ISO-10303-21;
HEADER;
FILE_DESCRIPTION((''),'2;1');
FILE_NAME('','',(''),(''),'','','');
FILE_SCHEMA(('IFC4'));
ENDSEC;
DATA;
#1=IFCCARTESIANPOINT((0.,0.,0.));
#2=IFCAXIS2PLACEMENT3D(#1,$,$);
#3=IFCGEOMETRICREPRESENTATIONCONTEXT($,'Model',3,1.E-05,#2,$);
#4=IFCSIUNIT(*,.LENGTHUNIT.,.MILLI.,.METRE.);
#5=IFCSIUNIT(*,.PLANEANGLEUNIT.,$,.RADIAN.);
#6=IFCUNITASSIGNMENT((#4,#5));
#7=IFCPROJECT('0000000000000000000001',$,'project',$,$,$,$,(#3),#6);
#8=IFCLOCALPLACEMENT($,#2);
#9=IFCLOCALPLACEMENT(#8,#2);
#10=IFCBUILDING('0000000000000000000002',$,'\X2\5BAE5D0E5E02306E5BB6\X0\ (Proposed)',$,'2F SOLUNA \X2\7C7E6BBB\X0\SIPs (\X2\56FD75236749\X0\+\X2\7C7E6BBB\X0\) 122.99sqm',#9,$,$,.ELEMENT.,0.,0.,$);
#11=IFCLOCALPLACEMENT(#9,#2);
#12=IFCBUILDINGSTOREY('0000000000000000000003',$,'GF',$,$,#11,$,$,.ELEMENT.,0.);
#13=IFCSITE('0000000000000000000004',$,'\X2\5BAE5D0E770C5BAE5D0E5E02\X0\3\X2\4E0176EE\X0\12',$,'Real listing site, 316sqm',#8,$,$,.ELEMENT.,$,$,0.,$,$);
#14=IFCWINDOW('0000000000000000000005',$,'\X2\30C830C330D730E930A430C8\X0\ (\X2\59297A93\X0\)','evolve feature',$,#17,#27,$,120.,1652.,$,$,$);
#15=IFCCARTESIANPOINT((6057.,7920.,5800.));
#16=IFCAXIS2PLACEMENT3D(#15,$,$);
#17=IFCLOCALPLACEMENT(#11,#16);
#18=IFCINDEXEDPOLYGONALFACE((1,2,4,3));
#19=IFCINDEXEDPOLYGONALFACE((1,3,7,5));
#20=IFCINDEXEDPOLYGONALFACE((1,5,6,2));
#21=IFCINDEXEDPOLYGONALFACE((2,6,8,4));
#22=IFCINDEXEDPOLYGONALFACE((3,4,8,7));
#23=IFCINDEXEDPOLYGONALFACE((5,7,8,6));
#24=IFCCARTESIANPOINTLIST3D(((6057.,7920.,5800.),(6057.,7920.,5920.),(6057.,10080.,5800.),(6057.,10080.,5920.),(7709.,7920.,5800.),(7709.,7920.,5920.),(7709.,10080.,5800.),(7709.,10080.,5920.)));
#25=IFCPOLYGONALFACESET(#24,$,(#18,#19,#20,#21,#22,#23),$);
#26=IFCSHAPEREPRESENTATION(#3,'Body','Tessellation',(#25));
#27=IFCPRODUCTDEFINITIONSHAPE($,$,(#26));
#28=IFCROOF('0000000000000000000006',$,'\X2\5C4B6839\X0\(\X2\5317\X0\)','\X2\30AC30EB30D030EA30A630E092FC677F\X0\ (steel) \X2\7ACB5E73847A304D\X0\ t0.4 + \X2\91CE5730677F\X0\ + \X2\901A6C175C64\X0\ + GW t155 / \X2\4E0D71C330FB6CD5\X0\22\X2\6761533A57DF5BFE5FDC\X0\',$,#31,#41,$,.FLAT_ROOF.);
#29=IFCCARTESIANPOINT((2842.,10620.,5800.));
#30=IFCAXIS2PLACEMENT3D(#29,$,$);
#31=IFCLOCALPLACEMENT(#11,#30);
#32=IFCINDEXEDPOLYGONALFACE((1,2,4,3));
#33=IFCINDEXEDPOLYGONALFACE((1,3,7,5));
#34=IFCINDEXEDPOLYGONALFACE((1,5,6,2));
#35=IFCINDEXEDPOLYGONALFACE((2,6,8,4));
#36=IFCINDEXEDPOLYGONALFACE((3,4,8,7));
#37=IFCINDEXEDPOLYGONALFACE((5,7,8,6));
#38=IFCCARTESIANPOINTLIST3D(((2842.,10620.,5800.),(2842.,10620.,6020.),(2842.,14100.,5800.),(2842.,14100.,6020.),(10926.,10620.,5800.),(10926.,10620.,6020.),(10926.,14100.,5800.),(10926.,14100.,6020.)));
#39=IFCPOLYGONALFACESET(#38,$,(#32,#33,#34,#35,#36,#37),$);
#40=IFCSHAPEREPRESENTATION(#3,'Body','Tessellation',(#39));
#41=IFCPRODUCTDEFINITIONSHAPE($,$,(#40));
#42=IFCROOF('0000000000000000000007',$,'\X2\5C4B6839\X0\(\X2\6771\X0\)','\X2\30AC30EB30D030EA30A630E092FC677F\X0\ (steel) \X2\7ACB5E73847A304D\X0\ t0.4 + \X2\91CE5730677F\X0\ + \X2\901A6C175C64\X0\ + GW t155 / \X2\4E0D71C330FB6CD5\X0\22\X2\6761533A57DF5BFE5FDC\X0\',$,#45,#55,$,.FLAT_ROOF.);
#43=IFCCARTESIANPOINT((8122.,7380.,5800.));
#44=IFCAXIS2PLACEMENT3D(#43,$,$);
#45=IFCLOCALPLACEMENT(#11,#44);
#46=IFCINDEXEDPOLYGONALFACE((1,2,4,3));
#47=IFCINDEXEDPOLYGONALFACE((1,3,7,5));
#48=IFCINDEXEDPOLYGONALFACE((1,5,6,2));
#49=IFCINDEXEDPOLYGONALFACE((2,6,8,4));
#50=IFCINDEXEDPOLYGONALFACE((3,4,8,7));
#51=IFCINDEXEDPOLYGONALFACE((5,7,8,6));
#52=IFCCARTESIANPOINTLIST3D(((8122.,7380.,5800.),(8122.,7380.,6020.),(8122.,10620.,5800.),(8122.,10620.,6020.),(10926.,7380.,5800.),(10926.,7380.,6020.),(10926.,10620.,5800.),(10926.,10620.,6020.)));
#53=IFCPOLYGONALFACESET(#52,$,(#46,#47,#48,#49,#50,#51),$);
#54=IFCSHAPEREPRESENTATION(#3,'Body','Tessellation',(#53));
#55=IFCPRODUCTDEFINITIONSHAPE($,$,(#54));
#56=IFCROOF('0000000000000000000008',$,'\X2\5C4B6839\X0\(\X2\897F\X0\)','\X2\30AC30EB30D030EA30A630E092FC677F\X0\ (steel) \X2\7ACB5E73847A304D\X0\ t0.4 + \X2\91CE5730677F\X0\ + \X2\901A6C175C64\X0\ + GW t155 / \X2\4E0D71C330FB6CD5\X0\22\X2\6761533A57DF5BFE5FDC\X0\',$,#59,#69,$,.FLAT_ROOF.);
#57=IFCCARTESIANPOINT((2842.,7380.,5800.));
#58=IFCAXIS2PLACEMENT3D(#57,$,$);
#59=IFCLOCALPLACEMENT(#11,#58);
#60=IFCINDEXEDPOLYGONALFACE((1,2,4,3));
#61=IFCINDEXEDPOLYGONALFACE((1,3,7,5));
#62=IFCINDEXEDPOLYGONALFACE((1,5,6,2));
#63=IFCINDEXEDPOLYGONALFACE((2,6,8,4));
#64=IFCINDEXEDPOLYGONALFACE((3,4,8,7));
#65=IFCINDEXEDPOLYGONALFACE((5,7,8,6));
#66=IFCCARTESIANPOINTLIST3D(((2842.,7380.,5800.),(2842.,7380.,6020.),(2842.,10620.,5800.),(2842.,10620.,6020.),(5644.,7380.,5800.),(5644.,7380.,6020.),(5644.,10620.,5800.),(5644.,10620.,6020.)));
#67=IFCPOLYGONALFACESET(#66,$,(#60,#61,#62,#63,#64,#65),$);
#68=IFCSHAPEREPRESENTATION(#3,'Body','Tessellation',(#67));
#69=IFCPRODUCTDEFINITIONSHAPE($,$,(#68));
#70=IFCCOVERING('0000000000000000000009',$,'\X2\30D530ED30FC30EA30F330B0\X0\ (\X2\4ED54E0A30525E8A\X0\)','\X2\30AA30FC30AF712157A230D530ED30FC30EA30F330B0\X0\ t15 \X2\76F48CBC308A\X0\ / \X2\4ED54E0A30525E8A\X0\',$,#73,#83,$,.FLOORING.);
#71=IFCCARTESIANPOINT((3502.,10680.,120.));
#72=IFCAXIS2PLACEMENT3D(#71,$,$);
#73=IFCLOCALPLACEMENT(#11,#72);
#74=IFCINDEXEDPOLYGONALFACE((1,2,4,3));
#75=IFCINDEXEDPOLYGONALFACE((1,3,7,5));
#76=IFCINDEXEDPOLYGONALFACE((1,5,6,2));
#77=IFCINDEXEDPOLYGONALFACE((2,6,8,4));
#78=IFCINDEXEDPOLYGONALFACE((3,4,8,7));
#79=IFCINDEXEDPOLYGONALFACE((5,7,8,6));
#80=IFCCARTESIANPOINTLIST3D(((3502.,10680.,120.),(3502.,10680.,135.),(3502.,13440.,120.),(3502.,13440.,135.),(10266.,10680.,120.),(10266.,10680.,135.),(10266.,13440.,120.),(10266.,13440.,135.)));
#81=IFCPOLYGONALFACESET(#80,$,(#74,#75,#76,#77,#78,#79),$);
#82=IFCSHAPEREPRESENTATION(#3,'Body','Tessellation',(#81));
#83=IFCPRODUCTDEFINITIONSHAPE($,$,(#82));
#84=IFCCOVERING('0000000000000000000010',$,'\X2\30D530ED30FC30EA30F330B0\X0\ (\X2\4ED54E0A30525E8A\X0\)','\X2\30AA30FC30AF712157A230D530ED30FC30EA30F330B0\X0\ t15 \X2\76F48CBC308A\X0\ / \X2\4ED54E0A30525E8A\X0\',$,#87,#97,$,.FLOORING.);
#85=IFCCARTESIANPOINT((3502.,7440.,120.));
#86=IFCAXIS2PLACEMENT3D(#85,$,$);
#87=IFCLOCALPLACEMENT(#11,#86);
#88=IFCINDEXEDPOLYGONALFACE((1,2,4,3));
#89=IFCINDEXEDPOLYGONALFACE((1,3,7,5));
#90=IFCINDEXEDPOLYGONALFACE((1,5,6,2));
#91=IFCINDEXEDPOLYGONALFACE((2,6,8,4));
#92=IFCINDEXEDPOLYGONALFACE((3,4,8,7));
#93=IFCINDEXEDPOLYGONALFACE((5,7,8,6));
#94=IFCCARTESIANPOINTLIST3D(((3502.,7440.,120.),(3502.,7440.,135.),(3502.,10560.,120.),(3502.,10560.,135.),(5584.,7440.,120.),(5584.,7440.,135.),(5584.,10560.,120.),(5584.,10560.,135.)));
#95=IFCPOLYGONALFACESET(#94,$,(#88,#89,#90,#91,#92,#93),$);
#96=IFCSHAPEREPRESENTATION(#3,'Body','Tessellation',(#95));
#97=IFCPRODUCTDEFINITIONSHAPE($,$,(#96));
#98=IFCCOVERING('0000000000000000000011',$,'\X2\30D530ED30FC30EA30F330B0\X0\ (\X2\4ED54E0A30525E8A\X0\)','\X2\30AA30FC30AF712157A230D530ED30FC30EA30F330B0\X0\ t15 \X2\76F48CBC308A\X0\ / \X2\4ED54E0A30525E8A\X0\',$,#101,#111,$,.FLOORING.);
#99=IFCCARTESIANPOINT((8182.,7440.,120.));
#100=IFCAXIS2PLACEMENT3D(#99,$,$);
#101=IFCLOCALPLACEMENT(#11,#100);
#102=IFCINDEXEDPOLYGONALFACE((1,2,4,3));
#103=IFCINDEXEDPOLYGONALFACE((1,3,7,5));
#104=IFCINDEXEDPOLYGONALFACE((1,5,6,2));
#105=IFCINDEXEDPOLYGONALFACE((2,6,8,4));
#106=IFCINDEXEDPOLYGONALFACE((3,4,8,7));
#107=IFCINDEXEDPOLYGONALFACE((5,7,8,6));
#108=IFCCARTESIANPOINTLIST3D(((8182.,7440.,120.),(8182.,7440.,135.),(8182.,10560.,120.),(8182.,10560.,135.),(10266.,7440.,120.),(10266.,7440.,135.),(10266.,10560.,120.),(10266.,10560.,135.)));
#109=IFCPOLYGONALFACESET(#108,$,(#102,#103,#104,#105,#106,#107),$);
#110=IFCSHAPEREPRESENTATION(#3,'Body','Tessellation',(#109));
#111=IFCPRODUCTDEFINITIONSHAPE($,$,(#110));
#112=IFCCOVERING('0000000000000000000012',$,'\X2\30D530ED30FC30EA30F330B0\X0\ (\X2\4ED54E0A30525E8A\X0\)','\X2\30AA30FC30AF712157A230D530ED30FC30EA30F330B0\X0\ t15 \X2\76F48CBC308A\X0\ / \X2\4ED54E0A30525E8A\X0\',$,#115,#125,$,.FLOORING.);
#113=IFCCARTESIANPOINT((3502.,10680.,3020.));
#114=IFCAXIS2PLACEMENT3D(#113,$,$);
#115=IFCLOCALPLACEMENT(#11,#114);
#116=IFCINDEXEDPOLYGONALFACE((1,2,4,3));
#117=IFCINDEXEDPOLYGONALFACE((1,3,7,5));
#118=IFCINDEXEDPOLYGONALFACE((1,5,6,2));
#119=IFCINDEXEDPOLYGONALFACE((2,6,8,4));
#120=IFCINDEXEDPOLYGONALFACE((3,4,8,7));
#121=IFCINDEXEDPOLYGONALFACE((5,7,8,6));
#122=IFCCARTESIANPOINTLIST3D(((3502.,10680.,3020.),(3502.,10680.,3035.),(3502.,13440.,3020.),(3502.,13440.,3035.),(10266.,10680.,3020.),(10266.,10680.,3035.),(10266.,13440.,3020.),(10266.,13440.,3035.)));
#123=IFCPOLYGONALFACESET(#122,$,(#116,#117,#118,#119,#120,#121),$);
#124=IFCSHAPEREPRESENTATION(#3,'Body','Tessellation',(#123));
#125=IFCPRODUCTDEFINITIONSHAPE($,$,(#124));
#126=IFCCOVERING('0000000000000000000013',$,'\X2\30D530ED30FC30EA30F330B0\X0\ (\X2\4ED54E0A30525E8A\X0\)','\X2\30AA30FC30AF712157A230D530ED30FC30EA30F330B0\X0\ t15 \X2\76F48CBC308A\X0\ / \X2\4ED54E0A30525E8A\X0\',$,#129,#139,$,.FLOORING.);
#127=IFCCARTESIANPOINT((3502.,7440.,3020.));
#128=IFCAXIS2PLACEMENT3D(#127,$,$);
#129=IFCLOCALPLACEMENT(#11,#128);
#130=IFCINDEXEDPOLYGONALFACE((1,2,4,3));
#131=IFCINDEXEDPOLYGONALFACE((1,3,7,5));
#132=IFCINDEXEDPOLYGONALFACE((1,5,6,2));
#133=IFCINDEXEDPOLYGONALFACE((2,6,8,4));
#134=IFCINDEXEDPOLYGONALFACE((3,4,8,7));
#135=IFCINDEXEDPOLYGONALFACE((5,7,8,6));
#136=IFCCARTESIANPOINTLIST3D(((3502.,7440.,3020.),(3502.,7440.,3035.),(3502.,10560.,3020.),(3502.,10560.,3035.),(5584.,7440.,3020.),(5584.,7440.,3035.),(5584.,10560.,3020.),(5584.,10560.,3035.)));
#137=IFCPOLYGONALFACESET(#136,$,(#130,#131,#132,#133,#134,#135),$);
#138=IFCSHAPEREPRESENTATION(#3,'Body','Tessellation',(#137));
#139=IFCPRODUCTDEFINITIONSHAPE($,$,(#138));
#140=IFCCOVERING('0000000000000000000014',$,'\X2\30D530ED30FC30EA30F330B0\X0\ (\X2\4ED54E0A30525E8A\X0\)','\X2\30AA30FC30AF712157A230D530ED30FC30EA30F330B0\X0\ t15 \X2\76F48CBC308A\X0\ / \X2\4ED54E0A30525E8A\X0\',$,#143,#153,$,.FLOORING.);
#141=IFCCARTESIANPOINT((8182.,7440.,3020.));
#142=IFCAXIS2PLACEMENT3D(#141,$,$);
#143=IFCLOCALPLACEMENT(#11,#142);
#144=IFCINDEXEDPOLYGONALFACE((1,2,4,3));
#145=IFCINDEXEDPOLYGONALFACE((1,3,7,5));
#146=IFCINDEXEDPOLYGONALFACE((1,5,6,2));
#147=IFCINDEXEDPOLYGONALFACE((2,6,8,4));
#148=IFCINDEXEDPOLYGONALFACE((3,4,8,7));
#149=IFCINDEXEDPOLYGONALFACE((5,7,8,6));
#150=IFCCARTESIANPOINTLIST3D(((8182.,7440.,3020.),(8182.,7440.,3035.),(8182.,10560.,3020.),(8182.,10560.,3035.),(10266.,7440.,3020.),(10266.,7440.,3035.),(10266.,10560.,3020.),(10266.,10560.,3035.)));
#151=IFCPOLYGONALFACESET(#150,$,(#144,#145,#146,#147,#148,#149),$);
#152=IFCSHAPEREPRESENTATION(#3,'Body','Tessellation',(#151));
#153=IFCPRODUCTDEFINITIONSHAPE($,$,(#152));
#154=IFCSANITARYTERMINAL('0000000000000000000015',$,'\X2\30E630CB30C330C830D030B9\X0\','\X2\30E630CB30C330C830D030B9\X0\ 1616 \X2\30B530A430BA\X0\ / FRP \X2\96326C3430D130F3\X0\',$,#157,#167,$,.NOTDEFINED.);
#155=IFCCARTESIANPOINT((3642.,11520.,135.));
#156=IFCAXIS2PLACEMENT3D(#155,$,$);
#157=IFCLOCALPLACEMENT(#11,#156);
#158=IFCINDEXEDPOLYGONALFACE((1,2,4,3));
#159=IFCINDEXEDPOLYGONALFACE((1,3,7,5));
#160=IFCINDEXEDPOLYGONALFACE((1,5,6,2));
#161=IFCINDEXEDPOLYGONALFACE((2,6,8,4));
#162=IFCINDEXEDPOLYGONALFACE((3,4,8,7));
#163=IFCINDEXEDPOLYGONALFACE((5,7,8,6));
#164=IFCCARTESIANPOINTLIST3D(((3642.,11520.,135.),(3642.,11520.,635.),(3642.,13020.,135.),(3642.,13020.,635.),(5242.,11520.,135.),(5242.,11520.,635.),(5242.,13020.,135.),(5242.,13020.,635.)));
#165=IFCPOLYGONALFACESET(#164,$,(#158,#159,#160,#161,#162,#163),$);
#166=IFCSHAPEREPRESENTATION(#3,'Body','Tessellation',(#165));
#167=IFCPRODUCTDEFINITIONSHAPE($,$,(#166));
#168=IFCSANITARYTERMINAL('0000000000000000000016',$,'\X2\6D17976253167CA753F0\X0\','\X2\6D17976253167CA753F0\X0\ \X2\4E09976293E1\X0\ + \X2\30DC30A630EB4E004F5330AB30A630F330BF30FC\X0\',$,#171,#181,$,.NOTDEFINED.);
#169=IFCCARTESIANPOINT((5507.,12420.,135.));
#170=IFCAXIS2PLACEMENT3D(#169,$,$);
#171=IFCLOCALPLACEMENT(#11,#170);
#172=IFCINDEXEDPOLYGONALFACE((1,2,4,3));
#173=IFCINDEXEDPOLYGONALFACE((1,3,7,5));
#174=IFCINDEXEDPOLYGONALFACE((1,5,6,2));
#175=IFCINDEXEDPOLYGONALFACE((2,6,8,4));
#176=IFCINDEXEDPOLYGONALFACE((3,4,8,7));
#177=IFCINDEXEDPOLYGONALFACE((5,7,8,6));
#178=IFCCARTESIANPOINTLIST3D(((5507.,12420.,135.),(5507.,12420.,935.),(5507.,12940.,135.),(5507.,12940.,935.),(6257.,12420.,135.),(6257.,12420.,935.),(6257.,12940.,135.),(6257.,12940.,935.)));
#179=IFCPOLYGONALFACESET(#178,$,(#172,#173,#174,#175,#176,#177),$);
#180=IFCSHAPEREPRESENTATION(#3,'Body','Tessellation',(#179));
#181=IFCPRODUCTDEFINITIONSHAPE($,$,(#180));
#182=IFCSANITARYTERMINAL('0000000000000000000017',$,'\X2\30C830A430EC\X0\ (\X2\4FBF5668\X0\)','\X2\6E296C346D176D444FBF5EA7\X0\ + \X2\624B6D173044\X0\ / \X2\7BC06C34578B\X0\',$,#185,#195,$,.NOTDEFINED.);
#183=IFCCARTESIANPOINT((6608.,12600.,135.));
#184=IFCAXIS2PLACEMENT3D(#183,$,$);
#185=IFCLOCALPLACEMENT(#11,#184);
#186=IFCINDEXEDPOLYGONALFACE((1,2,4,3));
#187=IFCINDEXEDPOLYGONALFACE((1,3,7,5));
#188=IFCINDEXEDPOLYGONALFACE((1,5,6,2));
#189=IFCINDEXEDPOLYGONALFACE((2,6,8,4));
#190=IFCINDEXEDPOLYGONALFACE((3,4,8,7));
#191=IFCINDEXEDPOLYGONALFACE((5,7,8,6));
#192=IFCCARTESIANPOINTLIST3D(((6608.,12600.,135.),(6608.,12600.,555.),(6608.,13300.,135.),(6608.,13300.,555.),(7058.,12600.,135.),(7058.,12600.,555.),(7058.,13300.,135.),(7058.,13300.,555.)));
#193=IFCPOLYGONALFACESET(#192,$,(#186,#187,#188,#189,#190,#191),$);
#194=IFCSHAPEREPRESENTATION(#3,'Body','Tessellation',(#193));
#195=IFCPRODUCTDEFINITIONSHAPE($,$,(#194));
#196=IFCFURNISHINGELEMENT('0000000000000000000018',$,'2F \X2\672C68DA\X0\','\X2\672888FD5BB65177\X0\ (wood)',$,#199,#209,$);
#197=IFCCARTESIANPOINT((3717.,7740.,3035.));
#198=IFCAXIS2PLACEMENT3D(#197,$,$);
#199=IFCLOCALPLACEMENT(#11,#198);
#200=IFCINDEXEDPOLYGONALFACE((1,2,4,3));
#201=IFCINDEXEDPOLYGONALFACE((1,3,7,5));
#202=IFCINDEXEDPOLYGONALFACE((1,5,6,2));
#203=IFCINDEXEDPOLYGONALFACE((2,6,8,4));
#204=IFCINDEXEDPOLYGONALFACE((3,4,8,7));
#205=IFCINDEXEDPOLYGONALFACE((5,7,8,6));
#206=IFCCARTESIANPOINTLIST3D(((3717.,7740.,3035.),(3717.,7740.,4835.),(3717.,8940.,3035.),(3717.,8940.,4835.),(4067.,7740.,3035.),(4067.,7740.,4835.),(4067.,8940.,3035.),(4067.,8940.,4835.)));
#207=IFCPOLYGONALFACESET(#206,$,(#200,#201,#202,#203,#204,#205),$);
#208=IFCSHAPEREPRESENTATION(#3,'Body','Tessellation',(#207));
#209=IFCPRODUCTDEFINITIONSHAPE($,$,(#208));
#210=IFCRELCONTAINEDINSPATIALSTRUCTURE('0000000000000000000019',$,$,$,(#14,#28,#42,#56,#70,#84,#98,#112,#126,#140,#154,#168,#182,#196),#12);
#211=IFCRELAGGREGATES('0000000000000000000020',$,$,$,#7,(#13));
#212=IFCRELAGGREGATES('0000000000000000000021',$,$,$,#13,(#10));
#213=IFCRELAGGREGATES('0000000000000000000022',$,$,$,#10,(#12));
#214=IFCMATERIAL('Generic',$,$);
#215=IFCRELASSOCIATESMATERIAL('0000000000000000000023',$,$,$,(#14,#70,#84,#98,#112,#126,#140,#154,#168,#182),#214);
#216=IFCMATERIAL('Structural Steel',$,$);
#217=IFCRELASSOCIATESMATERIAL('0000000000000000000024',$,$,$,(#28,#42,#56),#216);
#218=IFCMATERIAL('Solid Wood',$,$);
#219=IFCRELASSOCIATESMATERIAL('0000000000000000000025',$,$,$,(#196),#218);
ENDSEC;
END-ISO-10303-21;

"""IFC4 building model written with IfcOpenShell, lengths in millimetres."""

from ifc_helpers import new_model, si_unit, frame, frame_2d, origin, place, context, project, spatial, rectangle, extrude, material, element, save


model = new_model("IFC4")

# Units and contexts
model_context = context("Model", 3, precision=1e-05, world=origin())
ifc_project = project(units=[si_unit("LENGTHUNIT", "METRE", prefix="MILLI"), si_unit("PLANEANGLEUNIT", "RADIAN")], contexts=[model_context])

# Site, building, storey
site_placement = place(None, origin())
site = spatial("IfcSite", under=ifc_project, at=site_placement, Name="宮崎県宮崎市3丁目12", ObjectType="Real listing site, 316sqm", CompositionType="ELEMENT", RefElevation=0.0)
building_placement = place(site_placement, origin())
building = spatial("IfcBuilding", under=site, at=building_placement, Name="宮崎市の家 (Proposed)", ObjectType="2F SOLUNA 籾殻SIPs (国産杉+籾殻) 122.99sqm", CompositionType="ELEMENT", ElevationOfRefHeight=0.0, ElevationOfTerrain=0.0)
storey_placement = place(building_placement, origin())
storey = spatial("IfcBuildingStorey", under=building, at=storey_placement, Name="GF", CompositionType="ELEMENT", Elevation=0.0)

# Shared definitions
ifc_material_1 = material(Name="Solid Wood")

# Window
ifc_material_2 = material(Name="Generic")
window_1_placement = place(storey_placement, frame((6057.0, 7920.0, 5800.0)))
element("IfcWindow", 1, at=window_1_placement, inside=storey, material=ifc_material_2, Name="トップライト (天窓)", Description="evolve feature", OverallHeight=120.0, OverallWidth=1652.0, context=model_context, shape_type="SweptSolid", body=[
    extrude(rectangle(XDim=1652.0, YDim=2160.0, at=frame_2d((826.0, 1080.0))), frame((6057.0, 7920.0, 5800.0)), (0.0, 0.0, 1.0), 120.0),
])

# Roofs
ifc_material_3 = material(Name="Structural Steel")
roof_1_placement = place(storey_placement, frame((2842.0, 10620.0, 5800.0)))
element("IfcRoof", 2, at=roof_1_placement, inside=storey, material=ifc_material_3, Name="屋根(北)", Description="ガルバリウム鋼板 (steel) 立平葺き t0.4 + 野地板 + 通気層 + GW t155 / 不燃・法22条区域対応", PredefinedType="FLAT_ROOF", context=model_context, shape_type="SweptSolid", body=[
    extrude(rectangle(XDim=8084.0, YDim=3480.0, at=frame_2d((4042.0, 1740.0))), frame((2842.0, 10620.0, 5800.0)), (0.0, 0.0, 1.0), 220.0),
])
roof_2_placement = place(storey_placement, frame((8122.0, 7380.0, 5800.0)))
element("IfcRoof", 3, at=roof_2_placement, inside=storey, material=ifc_material_3, Name="屋根(東)", Description="ガルバリウム鋼板 (steel) 立平葺き t0.4 + 野地板 + 通気層 + GW t155 / 不燃・法22条区域対応", PredefinedType="FLAT_ROOF", context=model_context, shape_type="SweptSolid", body=[
    extrude(rectangle(XDim=2804.0, YDim=3240.0, at=frame_2d((1402.0, 1620.0))), frame((8122.0, 7380.0, 5800.0)), (0.0, 0.0, 1.0), 220.0),
])
roof_3_placement = place(storey_placement, frame((2842.0, 7380.0, 5800.0)))
element("IfcRoof", 4, at=roof_3_placement, inside=storey, material=ifc_material_3, Name="屋根(西)", Description="ガルバリウム鋼板 (steel) 立平葺き t0.4 + 野地板 + 通気層 + GW t155 / 不燃・法22条区域対応", PredefinedType="FLAT_ROOF", context=model_context, shape_type="SweptSolid", body=[
    extrude(rectangle(XDim=2802.0, YDim=3240.0, at=frame_2d((1401.0, 1620.0))), frame((2842.0, 7380.0, 5800.0)), (0.0, 0.0, 1.0), 220.0),
])

# Coverings
covering_1_placement = place(storey_placement, frame((3502.0, 10680.0, 120.0)))
element("IfcCovering", 5, at=covering_1_placement, inside=storey, material=ifc_material_2, Name="フローリング (仕上げ床)", Description="オーク無垢フローリング t15 直貼り / 仕上げ床", PredefinedType="FLOORING", context=model_context, shape_type="SweptSolid", body=[
    extrude(rectangle(XDim=6764.0, YDim=2760.0, at=frame_2d((3382.0, 1380.0))), frame((3502.0, 10680.0, 120.0)), (0.0, 0.0, 1.0), 15.0),
])
covering_2_placement = place(storey_placement, frame((3502.0, 7440.0, 120.0)))
element("IfcCovering", 6, at=covering_2_placement, inside=storey, material=ifc_material_2, Name="フローリング (仕上げ床)", Description="オーク無垢フローリング t15 直貼り / 仕上げ床", PredefinedType="FLOORING", context=model_context, shape_type="SweptSolid", body=[
    extrude(rectangle(XDim=2082.0, YDim=3120.0, at=frame_2d((1041.0, 1560.0))), frame((3502.0, 7440.0, 120.0)), (0.0, 0.0, 1.0), 15.0),
])
covering_3_placement = place(storey_placement, frame((8182.0, 7440.0, 120.0)))
element("IfcCovering", 7, at=covering_3_placement, inside=storey, material=ifc_material_2, Name="フローリング (仕上げ床)", Description="オーク無垢フローリング t15 直貼り / 仕上げ床", PredefinedType="FLOORING", context=model_context, shape_type="SweptSolid", body=[
    extrude(rectangle(XDim=2084.0, YDim=3120.0, at=frame_2d((1042.0, 1560.0))), frame((8182.0, 7440.0, 120.0)), (0.0, 0.0, 1.0), 15.0),
])
covering_4_placement = place(storey_placement, frame((3502.0, 10680.0, 3020.0)))
element("IfcCovering", 8, at=covering_4_placement, inside=storey, material=ifc_material_2, Name="フローリング (仕上げ床)", Description="オーク無垢フローリング t15 直貼り / 仕上げ床", PredefinedType="FLOORING", context=model_context, shape_type="SweptSolid", body=[
    extrude(rectangle(XDim=6764.0, YDim=2760.0, at=frame_2d((3382.0, 1380.0))), frame((3502.0, 10680.0, 3020.0)), (0.0, 0.0, 1.0), 15.0),
])
covering_5_placement = place(storey_placement, frame((3502.0, 7440.0, 3020.0)))
element("IfcCovering", 9, at=covering_5_placement, inside=storey, material=ifc_material_2, Name="フローリング (仕上げ床)", Description="オーク無垢フローリング t15 直貼り / 仕上げ床", PredefinedType="FLOORING", context=model_context, shape_type="SweptSolid", body=[
    extrude(rectangle(XDim=2082.0, YDim=3120.0, at=frame_2d((1041.0, 1560.0))), frame((3502.0, 7440.0, 3020.0)), (0.0, 0.0, 1.0), 15.0),
])
covering_6_placement = place(storey_placement, frame((8182.0, 7440.0, 3020.0)))
element("IfcCovering", 10, at=covering_6_placement, inside=storey, material=ifc_material_2, Name="フローリング (仕上げ床)", Description="オーク無垢フローリング t15 直貼り / 仕上げ床", PredefinedType="FLOORING", context=model_context, shape_type="SweptSolid", body=[
    extrude(rectangle(XDim=2084.0, YDim=3120.0, at=frame_2d((1042.0, 1560.0))), frame((8182.0, 7440.0, 3020.0)), (0.0, 0.0, 1.0), 15.0),
])

# Sanitary terminals
sanitary_terminal_1_placement = place(storey_placement, frame((3642.0, 11520.0, 135.0)))
element("IfcSanitaryTerminal", 11, at=sanitary_terminal_1_placement, inside=storey, material=ifc_material_2, Name="ユニットバス", Description="ユニットバス 1616 サイズ / FRP 防水パン", PredefinedType="NOTDEFINED", context=model_context, shape_type="SweptSolid", body=[
    extrude(rectangle(XDim=1600.0, YDim=1500.0, at=frame_2d((800.0, 750.0))), frame((3642.0, 11520.0, 135.0)), (0.0, 0.0, 1.0), 500.0),
])
sanitary_terminal_2_placement = place(storey_placement, frame((5507.0, 12420.0, 135.0)))
element("IfcSanitaryTerminal", 12, at=sanitary_terminal_2_placement, inside=storey, material=ifc_material_2, Name="洗面化粧台", Description="洗面化粧台 三面鏡 + ボウル一体カウンター", PredefinedType="NOTDEFINED", context=model_context, shape_type="SweptSolid", body=[
    extrude(rectangle(XDim=750.0, YDim=520.0, at=frame_2d((375.0, 260.0))), frame((5507.0, 12420.0, 135.0)), (0.0, 0.0, 1.0), 800.0),
])
sanitary_terminal_3_placement = place(storey_placement, frame((6608.0, 12600.0, 135.0)))
element("IfcSanitaryTerminal", 13, at=sanitary_terminal_3_placement, inside=storey, material=ifc_material_2, Name="トイレ (便器)", Description="温水洗浄便座 + 手洗い / 節水型", PredefinedType="NOTDEFINED", context=model_context, shape_type="SweptSolid", body=[
    extrude(rectangle(XDim=450.0, YDim=700.0, at=frame_2d((225.0, 350.0))), frame((6608.0, 12600.0, 135.0)), (0.0, 0.0, 1.0), 420.0),
])

# Furnishing element
furnishing_placement = place(storey_placement, frame((3717.0, 7740.0, 3035.0)))
element("IfcFurnishingElement", 14, at=furnishing_placement, inside=storey, material=ifc_material_1, Name="2F 本棚", Description="木製家具 (wood)", context=model_context, shape_type="SweptSolid", body=[
    extrude(rectangle(XDim=350.0, YDim=1200.0, at=frame_2d((175.0, 600.0))), frame((3717.0, 7740.0, 3035.0)), (0.0, 0.0, 1.0), 1800.0),
])

save(model, "model.ifc")
